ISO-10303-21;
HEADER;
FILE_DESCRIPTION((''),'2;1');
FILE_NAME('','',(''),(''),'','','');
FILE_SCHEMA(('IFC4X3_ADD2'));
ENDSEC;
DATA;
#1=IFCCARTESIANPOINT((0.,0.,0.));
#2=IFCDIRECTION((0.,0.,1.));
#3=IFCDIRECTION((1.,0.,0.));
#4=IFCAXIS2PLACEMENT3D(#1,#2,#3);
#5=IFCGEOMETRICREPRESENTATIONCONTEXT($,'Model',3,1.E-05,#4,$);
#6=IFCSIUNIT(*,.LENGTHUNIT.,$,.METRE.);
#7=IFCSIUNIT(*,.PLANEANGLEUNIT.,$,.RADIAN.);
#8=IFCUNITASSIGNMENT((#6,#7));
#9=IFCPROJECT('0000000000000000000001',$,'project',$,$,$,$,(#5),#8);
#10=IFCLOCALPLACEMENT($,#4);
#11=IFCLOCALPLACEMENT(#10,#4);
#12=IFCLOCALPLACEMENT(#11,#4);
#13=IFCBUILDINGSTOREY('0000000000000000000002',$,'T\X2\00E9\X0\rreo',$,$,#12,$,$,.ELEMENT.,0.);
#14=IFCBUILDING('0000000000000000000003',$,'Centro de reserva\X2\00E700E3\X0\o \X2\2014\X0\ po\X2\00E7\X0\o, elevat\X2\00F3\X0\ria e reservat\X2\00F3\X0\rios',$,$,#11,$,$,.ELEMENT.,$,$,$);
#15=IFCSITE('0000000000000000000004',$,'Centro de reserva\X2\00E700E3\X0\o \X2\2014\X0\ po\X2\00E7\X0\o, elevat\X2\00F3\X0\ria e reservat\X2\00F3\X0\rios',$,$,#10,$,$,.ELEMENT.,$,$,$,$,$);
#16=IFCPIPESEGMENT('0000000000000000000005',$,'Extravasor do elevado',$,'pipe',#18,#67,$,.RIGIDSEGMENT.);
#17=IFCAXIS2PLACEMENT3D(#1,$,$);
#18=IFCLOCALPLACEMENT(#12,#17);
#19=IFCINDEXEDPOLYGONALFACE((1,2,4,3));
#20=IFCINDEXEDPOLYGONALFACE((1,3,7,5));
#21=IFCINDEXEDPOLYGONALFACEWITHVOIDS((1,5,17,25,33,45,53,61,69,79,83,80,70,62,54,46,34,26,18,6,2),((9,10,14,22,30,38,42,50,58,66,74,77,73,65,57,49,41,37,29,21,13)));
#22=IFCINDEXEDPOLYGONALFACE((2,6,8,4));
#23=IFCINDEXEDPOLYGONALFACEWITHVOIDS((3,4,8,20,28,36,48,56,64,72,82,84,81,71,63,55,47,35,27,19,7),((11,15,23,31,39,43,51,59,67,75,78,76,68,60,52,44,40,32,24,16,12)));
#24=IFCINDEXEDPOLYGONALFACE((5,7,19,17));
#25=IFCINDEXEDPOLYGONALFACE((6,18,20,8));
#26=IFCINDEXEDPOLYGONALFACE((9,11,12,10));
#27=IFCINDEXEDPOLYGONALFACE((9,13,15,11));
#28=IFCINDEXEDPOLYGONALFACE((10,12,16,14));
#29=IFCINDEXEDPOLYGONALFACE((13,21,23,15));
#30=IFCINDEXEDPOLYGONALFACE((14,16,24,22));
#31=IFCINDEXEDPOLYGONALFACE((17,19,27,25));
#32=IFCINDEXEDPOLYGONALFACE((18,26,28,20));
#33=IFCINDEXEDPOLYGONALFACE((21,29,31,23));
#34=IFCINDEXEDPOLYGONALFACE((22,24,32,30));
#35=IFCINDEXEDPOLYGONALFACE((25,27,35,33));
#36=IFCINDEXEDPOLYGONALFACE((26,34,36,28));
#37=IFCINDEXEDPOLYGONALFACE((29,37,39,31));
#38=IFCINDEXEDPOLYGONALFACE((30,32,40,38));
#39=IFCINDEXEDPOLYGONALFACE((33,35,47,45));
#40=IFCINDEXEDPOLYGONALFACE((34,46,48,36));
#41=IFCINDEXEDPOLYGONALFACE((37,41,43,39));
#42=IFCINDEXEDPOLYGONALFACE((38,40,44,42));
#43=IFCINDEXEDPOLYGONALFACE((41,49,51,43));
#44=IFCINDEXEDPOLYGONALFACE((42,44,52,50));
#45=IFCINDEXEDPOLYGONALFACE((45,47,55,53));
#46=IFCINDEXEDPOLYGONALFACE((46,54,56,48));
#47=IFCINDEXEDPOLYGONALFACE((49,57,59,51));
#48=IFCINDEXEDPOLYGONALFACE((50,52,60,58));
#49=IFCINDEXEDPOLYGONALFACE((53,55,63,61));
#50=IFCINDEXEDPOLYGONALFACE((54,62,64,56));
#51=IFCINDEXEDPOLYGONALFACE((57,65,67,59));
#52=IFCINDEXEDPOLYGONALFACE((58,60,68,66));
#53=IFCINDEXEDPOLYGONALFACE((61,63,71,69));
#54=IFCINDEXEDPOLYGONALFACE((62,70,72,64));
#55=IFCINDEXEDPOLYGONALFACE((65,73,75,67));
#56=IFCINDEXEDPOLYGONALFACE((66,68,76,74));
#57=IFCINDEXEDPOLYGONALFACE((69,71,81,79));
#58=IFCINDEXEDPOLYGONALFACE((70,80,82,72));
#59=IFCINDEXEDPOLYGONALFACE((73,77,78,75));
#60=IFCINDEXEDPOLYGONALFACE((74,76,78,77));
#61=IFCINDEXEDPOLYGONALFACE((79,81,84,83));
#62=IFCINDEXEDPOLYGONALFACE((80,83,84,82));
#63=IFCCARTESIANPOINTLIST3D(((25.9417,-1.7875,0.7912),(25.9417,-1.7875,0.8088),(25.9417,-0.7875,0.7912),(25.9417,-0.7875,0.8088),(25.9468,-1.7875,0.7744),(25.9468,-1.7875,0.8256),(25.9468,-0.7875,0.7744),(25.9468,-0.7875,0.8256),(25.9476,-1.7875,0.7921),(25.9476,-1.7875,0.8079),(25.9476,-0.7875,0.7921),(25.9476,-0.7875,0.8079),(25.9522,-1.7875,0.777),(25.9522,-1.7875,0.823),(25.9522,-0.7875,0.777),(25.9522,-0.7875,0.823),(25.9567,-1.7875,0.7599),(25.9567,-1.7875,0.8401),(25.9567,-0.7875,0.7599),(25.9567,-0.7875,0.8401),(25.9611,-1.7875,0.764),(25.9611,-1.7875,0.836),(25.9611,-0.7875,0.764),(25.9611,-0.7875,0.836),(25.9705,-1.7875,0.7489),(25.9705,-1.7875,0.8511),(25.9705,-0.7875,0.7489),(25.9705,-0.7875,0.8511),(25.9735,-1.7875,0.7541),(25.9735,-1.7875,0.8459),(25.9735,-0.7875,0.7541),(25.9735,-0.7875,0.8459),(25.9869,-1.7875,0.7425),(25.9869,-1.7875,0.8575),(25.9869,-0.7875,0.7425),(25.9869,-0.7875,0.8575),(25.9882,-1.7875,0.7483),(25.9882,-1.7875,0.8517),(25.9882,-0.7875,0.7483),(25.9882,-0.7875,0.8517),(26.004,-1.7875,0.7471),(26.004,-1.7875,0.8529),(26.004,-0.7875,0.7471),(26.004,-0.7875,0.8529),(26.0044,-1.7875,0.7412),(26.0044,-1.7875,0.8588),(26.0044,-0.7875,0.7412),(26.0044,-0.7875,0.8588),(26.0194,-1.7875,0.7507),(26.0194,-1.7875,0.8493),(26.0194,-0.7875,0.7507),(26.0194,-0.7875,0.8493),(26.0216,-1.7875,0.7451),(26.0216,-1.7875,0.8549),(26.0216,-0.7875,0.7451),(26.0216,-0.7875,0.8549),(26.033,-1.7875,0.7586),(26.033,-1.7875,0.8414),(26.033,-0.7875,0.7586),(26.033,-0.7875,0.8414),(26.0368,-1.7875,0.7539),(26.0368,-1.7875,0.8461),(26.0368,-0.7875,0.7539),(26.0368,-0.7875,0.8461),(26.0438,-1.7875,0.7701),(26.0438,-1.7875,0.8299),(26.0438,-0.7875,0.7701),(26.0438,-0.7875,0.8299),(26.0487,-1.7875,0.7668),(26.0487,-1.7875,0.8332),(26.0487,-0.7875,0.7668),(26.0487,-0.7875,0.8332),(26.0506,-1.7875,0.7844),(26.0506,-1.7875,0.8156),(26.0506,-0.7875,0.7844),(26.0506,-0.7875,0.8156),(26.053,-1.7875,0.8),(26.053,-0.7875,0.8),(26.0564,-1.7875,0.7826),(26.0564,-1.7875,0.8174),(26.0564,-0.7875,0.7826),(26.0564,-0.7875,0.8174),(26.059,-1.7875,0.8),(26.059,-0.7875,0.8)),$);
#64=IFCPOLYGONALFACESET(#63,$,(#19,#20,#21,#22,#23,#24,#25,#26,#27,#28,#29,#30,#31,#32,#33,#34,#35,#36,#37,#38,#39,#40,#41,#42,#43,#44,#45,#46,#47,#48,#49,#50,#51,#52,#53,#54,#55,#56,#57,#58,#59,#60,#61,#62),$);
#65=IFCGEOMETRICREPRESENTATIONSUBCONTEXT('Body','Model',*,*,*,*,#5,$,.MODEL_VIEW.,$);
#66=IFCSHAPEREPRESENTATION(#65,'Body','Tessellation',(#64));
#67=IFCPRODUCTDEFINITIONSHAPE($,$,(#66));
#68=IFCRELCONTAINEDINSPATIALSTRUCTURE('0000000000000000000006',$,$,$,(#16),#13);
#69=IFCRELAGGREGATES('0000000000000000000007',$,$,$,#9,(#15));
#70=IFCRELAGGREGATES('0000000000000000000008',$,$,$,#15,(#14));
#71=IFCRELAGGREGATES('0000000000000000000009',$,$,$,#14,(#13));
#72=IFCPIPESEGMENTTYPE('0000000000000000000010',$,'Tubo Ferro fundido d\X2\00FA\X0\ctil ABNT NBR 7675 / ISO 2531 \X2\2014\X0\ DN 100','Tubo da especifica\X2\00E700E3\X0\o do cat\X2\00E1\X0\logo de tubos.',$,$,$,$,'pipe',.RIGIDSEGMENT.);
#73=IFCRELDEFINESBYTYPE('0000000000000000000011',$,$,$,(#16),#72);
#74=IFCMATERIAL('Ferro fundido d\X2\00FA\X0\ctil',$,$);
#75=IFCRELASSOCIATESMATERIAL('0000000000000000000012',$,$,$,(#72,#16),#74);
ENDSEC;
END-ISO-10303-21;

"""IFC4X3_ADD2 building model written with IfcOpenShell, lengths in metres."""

from ifc_helpers import new_model, si_unit, frame, origin_with_axes, place, context, subcontext, project, spatial, hollow_circle, extrude, material, type_object, element, save


model = new_model("IFC4X3_ADD2")

# Units and contexts
model_context = context("Model", 3, precision=1e-05, world=origin_with_axes())
body_context = subcontext(model_context, "Body", "Model", "MODEL_VIEW")
ifc_project = project(units=[si_unit("LENGTHUNIT", "METRE"), si_unit("PLANEANGLEUNIT", "RADIAN")], contexts=[model_context])

# Site, building, storey
site_placement = place(None, origin_with_axes())
site = spatial("IfcSite", under=ifc_project, at=site_placement, Name="Centro de reservação — poço, elevatória e reservatórios", CompositionType="ELEMENT")
building_placement = place(site_placement, origin_with_axes())
building = spatial("IfcBuilding", under=site, at=building_placement, Name="Centro de reservação — poço, elevatória e reservatórios", CompositionType="ELEMENT")
storey_placement = place(building_placement, origin_with_axes())
storey = spatial("IfcBuildingStorey", under=building, at=storey_placement, Name="Térreo", CompositionType="ELEMENT", Elevation=0.0)

# Pipe segment
ifc_material = material(Name="Ferro fundido dúctil")
pipe_segment_type = type_object("IfcPipeSegmentType", Name="Tubo Ferro fundido dúctil ABNT NBR 7675 / ISO 2531 — DN 100", Description="Tubo da especificação do catálogo de tubos.", ElementType="pipe", PredefinedType="RIGIDSEGMENT", material=ifc_material)
pipe_segment_placement = place(storey_placement, frame((26.0, -0.7875, 0.8), z_axis=(0.0, 0.0, 1.0), x_axis=(0.0, -1.0, 0.0)))
element("IfcPipeSegment", 1, at=pipe_segment_placement, inside=storey, type_object=pipe_segment_type, material=ifc_material, Name="Extravasor do elevado", ObjectType="pipe", PredefinedType="RIGIDSEGMENT", context=body_context, shape_type="SweptSolid", body=[
    extrude(hollow_circle(Radius=0.059, WallThickness=0.006), frame((0.0, 0.0, 0.0), z_axis=(1.0, 0.0, 0.0), x_axis=(0.0, 1.0, 0.0)), (0.0, 0.0, 1.0), 1.0),
])

save(model, "model.ifc")
